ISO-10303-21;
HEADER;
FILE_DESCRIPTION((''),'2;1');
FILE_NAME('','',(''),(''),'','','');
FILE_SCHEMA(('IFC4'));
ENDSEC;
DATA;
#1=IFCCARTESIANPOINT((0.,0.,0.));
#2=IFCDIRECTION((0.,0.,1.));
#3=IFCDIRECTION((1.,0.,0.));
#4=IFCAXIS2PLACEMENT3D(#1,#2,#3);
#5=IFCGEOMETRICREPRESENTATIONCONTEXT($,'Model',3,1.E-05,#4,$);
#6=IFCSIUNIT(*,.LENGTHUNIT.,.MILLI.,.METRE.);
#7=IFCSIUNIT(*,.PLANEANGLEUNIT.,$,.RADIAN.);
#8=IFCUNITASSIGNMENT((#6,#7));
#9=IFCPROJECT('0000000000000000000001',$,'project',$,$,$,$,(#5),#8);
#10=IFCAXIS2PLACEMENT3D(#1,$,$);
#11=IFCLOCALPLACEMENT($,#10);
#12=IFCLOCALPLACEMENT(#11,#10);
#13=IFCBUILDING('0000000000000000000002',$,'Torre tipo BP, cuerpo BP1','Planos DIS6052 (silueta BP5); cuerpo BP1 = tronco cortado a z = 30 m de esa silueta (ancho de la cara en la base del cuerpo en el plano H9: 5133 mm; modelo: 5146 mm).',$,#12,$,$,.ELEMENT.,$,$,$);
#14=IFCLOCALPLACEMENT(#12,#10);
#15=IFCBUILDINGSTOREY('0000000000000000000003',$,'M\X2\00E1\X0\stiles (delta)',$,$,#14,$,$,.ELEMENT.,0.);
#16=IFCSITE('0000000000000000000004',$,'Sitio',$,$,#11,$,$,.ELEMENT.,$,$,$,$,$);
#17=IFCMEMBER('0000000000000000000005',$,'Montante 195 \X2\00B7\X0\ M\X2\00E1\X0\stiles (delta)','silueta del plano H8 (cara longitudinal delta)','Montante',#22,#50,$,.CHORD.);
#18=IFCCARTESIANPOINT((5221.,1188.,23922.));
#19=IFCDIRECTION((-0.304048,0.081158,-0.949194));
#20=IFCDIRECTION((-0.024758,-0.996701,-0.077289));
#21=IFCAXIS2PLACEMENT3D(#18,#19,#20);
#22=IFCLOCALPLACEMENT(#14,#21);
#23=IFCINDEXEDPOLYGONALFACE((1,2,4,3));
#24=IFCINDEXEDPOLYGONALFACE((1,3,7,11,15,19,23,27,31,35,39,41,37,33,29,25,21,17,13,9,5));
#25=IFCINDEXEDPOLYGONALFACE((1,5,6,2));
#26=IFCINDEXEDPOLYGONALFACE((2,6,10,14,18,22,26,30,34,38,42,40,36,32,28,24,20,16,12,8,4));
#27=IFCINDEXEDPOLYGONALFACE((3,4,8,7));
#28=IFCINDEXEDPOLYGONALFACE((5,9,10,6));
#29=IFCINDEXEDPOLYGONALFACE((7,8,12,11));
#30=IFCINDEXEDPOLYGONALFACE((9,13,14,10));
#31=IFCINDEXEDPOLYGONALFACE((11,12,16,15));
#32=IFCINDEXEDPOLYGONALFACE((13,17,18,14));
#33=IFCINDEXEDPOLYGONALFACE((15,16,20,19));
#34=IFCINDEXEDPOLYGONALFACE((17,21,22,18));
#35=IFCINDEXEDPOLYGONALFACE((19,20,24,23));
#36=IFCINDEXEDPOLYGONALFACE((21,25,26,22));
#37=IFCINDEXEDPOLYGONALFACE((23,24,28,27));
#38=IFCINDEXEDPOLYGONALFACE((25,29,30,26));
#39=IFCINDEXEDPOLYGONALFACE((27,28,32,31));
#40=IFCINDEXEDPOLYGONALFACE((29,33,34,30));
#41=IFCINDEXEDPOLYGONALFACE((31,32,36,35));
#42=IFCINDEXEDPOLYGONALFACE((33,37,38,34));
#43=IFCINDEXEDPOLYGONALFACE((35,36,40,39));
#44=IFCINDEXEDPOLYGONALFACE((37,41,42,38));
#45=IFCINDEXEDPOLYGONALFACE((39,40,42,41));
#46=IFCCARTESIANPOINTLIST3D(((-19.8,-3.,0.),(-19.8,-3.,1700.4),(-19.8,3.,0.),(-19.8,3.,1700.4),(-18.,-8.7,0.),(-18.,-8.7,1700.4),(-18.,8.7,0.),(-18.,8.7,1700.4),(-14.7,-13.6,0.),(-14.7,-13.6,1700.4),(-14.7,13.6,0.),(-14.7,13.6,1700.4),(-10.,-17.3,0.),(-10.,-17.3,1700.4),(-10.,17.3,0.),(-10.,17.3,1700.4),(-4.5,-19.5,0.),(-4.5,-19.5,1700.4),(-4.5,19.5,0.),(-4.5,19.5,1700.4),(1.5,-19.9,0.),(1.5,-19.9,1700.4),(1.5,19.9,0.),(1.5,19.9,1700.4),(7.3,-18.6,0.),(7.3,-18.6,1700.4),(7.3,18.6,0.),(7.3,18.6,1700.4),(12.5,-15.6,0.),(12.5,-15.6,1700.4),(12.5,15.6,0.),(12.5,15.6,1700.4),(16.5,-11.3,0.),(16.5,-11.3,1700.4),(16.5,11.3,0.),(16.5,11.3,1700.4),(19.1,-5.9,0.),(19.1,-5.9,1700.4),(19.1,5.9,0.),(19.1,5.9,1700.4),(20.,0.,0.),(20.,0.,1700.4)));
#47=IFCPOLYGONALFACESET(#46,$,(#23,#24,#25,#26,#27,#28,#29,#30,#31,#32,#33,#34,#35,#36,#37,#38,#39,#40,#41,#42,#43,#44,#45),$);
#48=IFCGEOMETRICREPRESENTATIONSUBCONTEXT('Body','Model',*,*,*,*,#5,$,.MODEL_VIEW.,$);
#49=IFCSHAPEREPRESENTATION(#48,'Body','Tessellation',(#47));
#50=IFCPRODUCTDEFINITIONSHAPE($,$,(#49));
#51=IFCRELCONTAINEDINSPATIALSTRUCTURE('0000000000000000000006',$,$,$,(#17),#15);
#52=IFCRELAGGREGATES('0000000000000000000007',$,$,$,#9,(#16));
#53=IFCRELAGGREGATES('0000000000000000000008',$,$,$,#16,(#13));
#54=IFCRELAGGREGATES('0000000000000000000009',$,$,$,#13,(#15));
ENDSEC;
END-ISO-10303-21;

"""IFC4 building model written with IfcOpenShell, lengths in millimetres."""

from ifc_helpers import new_model, si_unit, frame, origin, origin_with_axes, place, context, subcontext, project, spatial, circle, extrude, element, save


model = new_model("IFC4")

# Units and contexts
model_context = context("Model", 3, precision=1e-05, world=origin_with_axes())
body_context = subcontext(model_context, "Body", "Model", "MODEL_VIEW")
ifc_project = project(units=[si_unit("LENGTHUNIT", "METRE", prefix="MILLI"), si_unit("PLANEANGLEUNIT", "RADIAN")], contexts=[model_context])

# Site, building, storey
site_placement = place(None, origin())
site = spatial("IfcSite", under=ifc_project, at=site_placement, Name="Sitio", CompositionType="ELEMENT")
building_placement = place(site_placement, origin())
building = spatial("IfcBuilding", under=site, at=building_placement, Name="Torre tipo BP, cuerpo BP1", Description="Planos DIS6052 (silueta BP5); cuerpo BP1 = tronco cortado a z = 30 m de esa silueta (ancho de la cara en la base del cuerpo en el plano H9: 5133 mm; modelo: 5146 mm).", CompositionType="ELEMENT")
storey_placement = place(building_placement, origin())
storey = spatial("IfcBuildingStorey", under=building, at=storey_placement, Name="Mástiles (delta)", CompositionType="ELEMENT", Elevation=0.0)

# Member
for number, where, z_axis, x_axis, name in (
    (1, (5221.0, 1188.0, 23922.0), (-0.304048, 0.081158, -0.949194), (-0.024758, -0.996701, -0.077289), "Montante 195 · Mástiles (delta)"),
):
    element("IfcMember", number, at=place(storey_placement, frame(where, z_axis=z_axis, x_axis=x_axis)), inside=storey, Name=name, Description="silueta del plano H8 (cara longitudinal delta)", ObjectType="Montante", PredefinedType="CHORD", context=body_context, shape_type="SweptSolid", body=[
        extrude(circle(Radius=20.0), None, (0.0, 0.0, 1.0), 1700.4),
    ])

save(model, "model.ifc")
